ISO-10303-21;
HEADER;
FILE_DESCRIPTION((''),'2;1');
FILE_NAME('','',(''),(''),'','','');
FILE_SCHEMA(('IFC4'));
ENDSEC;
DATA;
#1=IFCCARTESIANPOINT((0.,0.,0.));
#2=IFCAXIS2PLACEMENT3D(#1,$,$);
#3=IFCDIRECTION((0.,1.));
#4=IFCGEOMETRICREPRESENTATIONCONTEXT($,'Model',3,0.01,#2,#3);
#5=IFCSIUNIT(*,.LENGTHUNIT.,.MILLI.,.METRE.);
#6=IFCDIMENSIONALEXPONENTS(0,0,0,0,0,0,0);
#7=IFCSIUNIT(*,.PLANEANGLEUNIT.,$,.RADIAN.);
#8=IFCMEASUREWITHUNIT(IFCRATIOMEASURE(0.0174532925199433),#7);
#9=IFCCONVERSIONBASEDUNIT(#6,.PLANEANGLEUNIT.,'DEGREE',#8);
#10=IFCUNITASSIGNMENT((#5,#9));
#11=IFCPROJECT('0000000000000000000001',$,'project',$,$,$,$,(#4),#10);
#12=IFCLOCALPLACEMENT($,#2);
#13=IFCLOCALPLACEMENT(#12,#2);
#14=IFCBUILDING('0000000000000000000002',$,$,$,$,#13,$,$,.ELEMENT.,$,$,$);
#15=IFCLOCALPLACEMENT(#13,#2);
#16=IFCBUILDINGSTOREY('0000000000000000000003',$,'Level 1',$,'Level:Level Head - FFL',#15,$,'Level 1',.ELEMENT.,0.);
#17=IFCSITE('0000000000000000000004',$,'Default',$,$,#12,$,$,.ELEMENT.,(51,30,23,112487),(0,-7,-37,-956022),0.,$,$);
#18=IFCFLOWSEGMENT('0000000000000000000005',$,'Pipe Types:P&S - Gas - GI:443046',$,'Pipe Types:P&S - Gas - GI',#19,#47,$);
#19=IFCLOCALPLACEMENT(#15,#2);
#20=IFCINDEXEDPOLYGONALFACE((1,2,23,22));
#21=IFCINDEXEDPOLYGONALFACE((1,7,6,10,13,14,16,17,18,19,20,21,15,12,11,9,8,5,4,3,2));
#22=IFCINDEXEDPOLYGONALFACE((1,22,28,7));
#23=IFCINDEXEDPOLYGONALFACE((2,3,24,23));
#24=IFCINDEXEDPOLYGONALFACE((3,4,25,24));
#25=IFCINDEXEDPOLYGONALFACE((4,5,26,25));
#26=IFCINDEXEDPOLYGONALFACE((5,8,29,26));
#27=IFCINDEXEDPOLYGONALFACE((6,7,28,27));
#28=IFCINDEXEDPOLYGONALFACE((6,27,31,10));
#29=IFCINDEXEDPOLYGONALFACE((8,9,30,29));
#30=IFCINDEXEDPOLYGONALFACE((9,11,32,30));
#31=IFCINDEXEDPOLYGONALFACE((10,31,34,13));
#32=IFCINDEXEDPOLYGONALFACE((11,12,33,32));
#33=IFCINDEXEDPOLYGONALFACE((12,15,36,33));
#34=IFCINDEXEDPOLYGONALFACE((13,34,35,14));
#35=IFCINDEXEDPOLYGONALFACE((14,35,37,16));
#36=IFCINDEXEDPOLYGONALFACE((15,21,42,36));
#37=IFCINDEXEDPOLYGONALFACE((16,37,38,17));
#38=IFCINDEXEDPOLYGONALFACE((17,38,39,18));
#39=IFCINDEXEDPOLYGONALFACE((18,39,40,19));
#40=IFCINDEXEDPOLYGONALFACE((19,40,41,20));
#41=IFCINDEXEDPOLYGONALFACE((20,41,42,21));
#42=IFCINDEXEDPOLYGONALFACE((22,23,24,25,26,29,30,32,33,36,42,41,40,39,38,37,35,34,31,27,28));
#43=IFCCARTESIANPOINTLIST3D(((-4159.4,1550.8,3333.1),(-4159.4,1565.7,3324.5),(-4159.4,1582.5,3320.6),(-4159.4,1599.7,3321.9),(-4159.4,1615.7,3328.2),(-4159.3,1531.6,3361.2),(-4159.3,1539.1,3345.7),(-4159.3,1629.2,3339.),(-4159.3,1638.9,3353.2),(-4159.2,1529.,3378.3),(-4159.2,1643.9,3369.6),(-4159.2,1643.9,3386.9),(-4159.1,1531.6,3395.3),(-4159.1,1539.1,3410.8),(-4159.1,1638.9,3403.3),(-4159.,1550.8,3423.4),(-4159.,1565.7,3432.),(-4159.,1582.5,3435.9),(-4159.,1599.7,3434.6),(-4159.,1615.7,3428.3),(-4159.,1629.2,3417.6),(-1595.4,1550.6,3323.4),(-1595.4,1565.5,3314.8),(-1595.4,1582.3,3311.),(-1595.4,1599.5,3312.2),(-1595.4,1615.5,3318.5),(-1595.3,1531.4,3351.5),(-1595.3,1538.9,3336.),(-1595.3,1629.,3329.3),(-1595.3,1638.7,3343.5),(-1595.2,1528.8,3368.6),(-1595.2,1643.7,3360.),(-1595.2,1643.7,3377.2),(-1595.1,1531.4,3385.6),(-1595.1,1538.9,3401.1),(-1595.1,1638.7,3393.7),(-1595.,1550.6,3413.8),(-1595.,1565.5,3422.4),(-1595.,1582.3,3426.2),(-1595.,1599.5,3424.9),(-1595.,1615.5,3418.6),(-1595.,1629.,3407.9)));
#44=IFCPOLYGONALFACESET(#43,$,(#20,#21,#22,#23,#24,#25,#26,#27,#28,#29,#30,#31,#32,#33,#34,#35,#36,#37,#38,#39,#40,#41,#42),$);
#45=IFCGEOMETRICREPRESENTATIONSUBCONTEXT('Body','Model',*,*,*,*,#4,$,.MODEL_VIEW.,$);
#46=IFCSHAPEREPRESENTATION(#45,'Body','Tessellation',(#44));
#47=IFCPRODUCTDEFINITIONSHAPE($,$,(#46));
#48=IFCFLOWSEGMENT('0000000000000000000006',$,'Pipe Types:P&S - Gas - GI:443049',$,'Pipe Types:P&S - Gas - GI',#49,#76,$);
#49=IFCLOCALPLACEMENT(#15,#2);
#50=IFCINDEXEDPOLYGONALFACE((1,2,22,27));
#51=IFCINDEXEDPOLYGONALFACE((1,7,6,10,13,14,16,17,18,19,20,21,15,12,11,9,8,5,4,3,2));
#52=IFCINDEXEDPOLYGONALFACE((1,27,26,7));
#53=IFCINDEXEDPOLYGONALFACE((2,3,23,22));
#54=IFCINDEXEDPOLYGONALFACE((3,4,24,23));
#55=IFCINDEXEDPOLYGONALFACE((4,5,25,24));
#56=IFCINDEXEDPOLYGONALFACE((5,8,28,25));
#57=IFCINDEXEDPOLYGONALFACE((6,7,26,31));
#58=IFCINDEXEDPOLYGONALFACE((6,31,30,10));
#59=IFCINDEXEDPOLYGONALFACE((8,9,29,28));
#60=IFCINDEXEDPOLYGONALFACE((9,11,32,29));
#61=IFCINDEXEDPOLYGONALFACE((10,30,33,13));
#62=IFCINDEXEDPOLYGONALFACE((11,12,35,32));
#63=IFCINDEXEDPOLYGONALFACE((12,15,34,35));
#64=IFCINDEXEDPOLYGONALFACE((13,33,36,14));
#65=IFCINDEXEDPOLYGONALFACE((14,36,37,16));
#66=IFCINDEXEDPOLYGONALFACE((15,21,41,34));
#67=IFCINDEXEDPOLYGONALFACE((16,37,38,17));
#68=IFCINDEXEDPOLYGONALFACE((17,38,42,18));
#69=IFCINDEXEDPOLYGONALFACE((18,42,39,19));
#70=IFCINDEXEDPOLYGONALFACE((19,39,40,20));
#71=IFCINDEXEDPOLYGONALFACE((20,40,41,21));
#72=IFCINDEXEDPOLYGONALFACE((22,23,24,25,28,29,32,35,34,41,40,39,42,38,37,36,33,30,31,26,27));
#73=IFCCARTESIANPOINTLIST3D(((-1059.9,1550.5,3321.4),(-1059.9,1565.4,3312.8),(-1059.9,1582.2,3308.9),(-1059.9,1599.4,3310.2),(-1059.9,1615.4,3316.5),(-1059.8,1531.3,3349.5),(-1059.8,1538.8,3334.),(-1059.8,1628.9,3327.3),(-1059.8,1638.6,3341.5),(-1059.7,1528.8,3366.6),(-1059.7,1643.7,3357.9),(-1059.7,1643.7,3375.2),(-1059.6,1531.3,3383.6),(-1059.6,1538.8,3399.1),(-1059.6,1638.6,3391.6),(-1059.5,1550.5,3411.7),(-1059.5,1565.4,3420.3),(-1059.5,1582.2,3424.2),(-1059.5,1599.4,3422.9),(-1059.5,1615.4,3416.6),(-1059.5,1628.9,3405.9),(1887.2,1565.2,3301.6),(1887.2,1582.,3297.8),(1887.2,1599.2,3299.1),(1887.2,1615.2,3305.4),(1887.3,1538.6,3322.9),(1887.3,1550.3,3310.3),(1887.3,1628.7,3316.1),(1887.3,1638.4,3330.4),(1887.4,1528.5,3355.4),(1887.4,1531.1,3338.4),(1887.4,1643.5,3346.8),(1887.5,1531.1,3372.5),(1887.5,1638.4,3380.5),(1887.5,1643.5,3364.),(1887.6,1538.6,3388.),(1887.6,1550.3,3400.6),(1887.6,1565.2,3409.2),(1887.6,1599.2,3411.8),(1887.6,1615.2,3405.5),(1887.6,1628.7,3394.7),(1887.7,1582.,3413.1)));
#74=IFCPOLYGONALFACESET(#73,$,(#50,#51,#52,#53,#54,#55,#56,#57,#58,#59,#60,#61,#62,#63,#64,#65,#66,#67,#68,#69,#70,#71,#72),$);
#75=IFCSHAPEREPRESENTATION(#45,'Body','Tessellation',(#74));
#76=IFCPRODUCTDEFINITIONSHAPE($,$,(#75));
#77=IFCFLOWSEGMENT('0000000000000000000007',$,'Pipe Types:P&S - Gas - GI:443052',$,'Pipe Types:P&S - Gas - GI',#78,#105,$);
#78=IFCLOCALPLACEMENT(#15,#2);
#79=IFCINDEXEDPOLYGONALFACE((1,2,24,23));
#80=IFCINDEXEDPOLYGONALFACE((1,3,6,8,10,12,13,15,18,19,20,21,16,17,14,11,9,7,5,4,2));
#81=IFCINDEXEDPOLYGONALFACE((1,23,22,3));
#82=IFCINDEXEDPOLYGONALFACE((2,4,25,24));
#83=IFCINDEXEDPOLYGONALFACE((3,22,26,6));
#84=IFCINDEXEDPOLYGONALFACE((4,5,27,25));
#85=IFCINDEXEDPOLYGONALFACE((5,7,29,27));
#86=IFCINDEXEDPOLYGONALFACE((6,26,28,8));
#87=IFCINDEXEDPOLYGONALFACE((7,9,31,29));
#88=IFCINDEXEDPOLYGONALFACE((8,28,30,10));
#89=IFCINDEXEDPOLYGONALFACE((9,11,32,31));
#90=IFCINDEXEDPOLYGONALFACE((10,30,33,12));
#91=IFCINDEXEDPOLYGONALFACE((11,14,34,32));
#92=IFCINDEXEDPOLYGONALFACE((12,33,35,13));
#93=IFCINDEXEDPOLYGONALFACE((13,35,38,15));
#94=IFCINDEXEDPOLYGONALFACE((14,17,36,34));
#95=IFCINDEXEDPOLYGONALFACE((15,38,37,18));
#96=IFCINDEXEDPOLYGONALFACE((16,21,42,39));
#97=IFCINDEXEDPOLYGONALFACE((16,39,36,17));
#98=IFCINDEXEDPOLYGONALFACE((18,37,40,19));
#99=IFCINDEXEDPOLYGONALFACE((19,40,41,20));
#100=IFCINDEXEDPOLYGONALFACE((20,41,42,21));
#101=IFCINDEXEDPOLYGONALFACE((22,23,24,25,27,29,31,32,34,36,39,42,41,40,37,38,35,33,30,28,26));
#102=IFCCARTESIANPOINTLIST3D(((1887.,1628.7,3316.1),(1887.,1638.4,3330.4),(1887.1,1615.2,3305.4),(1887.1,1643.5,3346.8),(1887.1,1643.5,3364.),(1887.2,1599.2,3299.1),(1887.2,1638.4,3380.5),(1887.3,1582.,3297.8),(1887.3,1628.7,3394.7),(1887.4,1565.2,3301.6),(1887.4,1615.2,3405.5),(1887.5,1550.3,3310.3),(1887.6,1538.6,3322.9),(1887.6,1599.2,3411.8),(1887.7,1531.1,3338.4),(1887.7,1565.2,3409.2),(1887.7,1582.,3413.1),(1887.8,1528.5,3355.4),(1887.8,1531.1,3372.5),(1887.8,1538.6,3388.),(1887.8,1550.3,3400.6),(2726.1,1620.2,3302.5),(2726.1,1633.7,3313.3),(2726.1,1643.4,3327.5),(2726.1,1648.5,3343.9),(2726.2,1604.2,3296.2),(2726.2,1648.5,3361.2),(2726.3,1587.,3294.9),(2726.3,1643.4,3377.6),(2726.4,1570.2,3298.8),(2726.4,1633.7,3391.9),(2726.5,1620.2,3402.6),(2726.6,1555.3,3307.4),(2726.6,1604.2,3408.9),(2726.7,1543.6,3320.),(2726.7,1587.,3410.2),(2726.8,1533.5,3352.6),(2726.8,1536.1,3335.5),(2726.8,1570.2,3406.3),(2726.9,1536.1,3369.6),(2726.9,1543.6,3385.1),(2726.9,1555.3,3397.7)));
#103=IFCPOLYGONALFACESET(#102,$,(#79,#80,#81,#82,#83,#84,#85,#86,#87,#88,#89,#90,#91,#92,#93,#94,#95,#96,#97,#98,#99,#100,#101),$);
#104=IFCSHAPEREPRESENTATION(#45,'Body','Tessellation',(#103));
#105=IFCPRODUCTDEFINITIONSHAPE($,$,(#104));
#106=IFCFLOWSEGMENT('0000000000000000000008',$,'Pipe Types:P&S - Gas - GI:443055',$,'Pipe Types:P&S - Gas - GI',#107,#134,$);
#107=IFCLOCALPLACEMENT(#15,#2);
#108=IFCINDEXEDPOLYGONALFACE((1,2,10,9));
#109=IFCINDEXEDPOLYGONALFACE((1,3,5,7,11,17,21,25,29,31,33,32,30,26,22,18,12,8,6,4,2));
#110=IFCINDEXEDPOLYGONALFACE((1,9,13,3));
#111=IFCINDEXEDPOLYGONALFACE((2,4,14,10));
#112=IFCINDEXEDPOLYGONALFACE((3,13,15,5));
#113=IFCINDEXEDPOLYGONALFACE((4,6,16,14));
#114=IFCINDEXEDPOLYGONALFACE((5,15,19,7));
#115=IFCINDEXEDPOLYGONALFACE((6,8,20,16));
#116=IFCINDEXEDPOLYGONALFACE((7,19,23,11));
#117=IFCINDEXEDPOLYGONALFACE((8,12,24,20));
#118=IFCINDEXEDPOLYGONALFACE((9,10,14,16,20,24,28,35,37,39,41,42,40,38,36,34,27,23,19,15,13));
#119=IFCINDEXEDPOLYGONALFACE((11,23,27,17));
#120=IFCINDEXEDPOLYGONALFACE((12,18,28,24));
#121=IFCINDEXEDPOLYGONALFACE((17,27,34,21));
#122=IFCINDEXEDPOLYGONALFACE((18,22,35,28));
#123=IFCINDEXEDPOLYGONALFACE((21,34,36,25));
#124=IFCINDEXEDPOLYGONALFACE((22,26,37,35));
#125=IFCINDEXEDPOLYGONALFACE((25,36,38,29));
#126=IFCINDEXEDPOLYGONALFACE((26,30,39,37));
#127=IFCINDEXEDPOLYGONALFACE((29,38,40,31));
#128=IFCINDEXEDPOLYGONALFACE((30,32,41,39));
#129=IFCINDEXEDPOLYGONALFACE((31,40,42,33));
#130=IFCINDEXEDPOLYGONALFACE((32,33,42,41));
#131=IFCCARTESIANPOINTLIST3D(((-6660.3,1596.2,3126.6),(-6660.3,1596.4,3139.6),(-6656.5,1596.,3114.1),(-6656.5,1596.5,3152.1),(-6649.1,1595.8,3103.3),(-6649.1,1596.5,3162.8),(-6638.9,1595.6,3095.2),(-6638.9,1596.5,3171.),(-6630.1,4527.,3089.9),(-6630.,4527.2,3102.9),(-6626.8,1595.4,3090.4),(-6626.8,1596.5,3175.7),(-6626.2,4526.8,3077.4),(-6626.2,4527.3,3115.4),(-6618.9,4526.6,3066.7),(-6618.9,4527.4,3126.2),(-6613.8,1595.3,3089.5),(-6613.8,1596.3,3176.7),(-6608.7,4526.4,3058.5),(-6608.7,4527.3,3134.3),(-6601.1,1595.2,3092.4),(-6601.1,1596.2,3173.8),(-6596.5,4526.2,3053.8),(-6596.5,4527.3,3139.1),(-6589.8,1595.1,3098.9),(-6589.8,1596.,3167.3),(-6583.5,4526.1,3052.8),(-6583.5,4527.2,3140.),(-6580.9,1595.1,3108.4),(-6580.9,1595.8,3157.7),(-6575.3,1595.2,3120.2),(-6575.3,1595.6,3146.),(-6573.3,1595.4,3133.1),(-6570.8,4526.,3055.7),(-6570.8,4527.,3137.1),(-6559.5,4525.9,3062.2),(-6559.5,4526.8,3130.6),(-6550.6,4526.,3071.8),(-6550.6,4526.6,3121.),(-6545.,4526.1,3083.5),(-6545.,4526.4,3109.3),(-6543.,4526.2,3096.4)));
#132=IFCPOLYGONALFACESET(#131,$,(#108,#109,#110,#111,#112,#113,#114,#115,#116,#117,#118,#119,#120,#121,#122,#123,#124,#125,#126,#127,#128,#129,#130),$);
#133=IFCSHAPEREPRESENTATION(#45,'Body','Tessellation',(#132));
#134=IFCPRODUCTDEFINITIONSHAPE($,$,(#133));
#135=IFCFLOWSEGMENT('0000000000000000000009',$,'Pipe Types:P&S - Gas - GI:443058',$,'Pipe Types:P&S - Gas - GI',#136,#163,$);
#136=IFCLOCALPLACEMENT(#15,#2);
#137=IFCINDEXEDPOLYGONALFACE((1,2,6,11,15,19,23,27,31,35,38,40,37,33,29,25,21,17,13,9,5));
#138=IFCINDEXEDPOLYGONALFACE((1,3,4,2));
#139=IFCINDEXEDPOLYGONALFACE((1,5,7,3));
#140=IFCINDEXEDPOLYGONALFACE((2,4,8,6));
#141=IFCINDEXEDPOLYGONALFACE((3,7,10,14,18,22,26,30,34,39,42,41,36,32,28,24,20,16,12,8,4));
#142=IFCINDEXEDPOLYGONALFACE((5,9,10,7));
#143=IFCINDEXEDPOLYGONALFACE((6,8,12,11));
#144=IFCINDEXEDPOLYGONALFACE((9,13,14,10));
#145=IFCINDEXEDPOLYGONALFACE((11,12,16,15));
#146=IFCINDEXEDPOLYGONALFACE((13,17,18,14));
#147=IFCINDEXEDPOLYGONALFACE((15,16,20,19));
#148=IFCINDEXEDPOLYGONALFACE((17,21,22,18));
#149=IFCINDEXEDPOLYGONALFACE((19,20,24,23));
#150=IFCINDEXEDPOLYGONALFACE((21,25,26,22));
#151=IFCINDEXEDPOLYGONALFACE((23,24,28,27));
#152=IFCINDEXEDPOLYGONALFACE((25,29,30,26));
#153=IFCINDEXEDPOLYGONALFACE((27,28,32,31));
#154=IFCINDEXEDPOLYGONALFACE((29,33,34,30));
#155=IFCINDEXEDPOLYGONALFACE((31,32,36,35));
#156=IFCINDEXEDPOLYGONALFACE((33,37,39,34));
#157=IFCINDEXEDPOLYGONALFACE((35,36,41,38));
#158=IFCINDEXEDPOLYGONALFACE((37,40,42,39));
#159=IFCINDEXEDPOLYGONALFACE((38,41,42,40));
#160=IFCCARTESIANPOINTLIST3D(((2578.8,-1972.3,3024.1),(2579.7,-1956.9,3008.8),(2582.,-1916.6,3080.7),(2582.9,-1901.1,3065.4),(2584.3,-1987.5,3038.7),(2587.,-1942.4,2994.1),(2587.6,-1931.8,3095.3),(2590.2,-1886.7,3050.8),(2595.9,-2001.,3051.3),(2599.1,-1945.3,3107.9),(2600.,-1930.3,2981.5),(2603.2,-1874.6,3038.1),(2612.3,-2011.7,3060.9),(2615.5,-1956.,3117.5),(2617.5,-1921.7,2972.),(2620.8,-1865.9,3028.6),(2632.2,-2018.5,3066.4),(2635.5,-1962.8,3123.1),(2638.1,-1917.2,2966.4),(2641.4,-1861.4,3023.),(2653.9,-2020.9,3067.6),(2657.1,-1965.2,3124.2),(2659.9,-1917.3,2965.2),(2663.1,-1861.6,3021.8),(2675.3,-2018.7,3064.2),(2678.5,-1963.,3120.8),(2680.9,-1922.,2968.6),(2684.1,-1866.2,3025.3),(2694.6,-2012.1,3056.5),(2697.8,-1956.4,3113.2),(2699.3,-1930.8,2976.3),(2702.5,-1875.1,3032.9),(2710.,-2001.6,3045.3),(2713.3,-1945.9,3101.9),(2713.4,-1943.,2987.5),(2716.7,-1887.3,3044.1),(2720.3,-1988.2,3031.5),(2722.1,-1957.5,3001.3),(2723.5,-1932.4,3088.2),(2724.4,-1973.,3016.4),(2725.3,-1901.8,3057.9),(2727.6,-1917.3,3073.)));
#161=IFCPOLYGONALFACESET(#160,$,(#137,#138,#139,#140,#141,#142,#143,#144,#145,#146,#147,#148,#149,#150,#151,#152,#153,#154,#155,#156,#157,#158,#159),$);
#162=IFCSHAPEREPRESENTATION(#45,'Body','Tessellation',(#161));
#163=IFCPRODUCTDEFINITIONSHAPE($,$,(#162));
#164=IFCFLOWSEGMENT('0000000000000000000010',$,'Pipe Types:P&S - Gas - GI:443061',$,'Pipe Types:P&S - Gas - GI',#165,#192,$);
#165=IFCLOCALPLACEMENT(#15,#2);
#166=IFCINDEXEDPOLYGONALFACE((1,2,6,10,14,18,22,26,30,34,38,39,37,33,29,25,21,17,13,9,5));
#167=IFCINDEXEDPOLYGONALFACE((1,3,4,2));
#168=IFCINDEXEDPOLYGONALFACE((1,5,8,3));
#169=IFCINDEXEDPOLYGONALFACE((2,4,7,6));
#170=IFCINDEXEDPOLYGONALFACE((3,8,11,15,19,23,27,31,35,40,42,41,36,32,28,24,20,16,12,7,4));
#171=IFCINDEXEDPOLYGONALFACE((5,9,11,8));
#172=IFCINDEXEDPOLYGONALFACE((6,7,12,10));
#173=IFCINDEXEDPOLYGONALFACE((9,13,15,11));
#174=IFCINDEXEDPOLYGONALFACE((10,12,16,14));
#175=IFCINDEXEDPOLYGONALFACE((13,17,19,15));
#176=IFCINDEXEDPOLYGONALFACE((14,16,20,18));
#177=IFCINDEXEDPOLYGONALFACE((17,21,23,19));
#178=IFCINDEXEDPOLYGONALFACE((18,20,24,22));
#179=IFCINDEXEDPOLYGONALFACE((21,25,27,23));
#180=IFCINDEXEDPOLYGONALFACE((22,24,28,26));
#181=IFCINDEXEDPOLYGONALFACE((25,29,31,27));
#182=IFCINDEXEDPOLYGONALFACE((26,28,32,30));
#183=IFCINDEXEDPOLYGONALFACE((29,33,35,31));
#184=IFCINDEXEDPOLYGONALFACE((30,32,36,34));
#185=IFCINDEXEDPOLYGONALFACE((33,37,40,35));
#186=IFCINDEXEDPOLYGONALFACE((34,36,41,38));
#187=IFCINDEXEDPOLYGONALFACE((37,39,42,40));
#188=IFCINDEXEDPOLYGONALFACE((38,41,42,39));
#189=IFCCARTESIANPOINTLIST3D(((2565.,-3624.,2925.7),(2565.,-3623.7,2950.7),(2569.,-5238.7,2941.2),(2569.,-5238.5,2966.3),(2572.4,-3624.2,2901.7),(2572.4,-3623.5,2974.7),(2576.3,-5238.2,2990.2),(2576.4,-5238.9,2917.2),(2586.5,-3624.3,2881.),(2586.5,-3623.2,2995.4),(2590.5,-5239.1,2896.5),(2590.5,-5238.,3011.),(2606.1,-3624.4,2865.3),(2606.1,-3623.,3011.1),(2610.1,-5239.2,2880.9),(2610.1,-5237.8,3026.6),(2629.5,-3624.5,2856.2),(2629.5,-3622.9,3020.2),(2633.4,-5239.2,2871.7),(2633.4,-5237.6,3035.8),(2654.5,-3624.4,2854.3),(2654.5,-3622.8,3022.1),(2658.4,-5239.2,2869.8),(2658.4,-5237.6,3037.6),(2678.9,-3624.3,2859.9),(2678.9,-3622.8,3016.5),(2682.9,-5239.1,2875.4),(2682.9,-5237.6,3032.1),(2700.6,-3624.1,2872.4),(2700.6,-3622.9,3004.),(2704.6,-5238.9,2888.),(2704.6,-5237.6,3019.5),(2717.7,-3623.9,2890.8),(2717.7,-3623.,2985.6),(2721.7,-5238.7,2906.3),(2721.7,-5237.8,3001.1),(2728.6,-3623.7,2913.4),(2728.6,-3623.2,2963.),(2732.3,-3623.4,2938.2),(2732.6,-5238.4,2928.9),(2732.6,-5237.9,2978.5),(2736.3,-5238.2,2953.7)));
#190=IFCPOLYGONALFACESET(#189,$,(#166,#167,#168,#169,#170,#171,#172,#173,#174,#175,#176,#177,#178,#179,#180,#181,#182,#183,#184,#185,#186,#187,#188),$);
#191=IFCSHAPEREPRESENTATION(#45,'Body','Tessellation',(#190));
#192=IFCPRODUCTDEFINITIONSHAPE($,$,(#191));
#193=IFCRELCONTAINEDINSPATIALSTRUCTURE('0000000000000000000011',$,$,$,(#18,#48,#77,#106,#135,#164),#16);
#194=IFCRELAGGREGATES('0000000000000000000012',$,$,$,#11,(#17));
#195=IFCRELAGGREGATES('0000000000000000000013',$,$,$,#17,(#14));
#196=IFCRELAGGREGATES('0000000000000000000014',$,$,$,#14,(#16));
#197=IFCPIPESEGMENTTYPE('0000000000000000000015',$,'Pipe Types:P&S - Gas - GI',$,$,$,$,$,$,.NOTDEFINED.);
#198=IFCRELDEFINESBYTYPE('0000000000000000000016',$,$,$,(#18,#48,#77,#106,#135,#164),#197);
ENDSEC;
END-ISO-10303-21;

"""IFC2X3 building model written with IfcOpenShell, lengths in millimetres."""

from ifc_helpers import new_model, entity, si_unit, converted_unit, direction, frame, frame_2d, origin, origin_2d_with_axis, place, context, subcontext, project, spatial, circle, extrude, type_object, element, save


model = new_model("IFC2X3")

# Units and contexts
model_context = context("Model", 3, precision=0.01, world=origin(), true_north=direction((0.0, 1.0)))
body_context = subcontext(model_context, "Body", "Model", "MODEL_VIEW")
ifc_project = project(units=[si_unit("LENGTHUNIT", "METRE", prefix="MILLI"), converted_unit("PLANEANGLEUNIT", "DEGREE", entity("IfcRatioMeasure", 0.0174532925199433), si_unit("PLANEANGLEUNIT", "RADIAN"), dimensions=[0, 0, 0, 0, 0, 0, 0])], contexts=[model_context])

# Site, building, storey
site_placement = place(None, origin())
site = spatial("IfcSite", under=ifc_project, at=site_placement, Name="Default", CompositionType="ELEMENT", RefLatitude=(51, 30, 23, 112487), RefLongitude=(0, -7, -37, -956022), RefElevation=0.0)
building_placement = place(site_placement, origin())
building = spatial("IfcBuilding", under=site, at=building_placement, CompositionType="ELEMENT")
storey_placement = place(building_placement, origin())
storey = spatial("IfcBuildingStorey", under=building, at=storey_placement, Name="Level 1", ObjectType="Level:Level Head - FFL", LongName="Level 1", CompositionType="ELEMENT", Elevation=0.0)

# Flow segments
pipe_segment_type = type_object("IfcPipeSegmentType", Name="Pipe Types:P&S - Gas - GI", PredefinedType="NOTDEFINED")
flow_segment_1_placement = place(storey_placement, origin())
element("IfcFlowSegment", 1, at=flow_segment_1_placement, inside=storey, type_object=pipe_segment_type, Name="Pipe Types:P&S - Gas - GI:443046", ObjectType="Pipe Types:P&S - Gas - GI", context=body_context, shape_type="SweptSolid", body=[
    extrude(circle(Radius=57.8, at=frame_2d((0.0, 0.0), x_axis=(1.0, 0.0))), frame((-1595.2, 1586.6, 3368.6), z_axis=(-0.999993, 0.000082, 0.003774), x_axis=(-0.000082, -1.0, 0.0)), (0.0, 0.0, 1.0), 2564.0),
])
flow_segment_2_placement = place(storey_placement, origin())
element("IfcFlowSegment", 2, at=flow_segment_2_placement, inside=storey, type_object=pipe_segment_type, Name="Pipe Types:P&S - Gas - GI:443049", ObjectType="Pipe Types:P&S - Gas - GI", context=body_context, shape_type="SweptSolid", body=[
    extrude(circle(Radius=57.8, at=frame_2d((0.0, 0.0), x_axis=(1.0, 0.0))), frame((1887.4, 1586.3, 3355.4), z_axis=(-0.999993, 0.000082, 0.003774), x_axis=(-0.000082, -1.0, 0.0)), (0.0, 0.0, 1.0), 2947.2),
])
flow_segment_3_placement = place(storey_placement, origin())
element("IfcFlowSegment", 3, at=flow_segment_3_placement, inside=storey, type_object=pipe_segment_type, Name="Pipe Types:P&S - Gas - GI:443052", ObjectType="Pipe Types:P&S - Gas - GI", context=body_context, shape_type="SweptSolid", body=[
    extrude(circle(Radius=57.8, at=origin_2d_with_axis()), frame((2726.5, 1591.3, 3352.6), z_axis=(-0.999976, -0.005975, 0.003428), x_axis=(0.005975, -0.999982, 0.0)), (0.0, 0.0, 1.0), 839.1),
])
flow_segment_4_placement = place(storey_placement, origin())
element("IfcFlowSegment", 4, at=flow_segment_4_placement, inside=storey, type_object=pipe_segment_type, Name="Pipe Types:P&S - Gas - GI:443055", ObjectType="Pipe Types:P&S - Gas - GI", context=body_context, shape_type="SweptSolid", body=[
    extrude(circle(Radius=43.7, at=frame_2d((0.0, 0.0), x_axis=(1.0, 0.0))), frame((-6586.8, 4526.6, 3096.4), z_axis=(-0.010329, -0.999868, 0.012514), x_axis=(0.999947, -0.010329, 0.0)), (0.0, 0.0, 1.0), 2931.2),
])
flow_segment_5_placement = place(storey_placement, origin())
element("IfcFlowSegment", 5, at=flow_segment_5_placement, inside=storey, type_object=pipe_segment_type, Name="Pipe Types:P&S - Gas - GI:443058", ObjectType="Pipe Types:P&S - Gas - GI", context=body_context, shape_type="SweptSolid", body=[
    extrude(circle(Radius=73.1, at=frame_2d((0.0, 0.0), x_axis=(1.0, 0.0))), frame((2651.4, -1968.8, 3016.4), z_axis=(0.040698, 0.700832, 0.712164), x_axis=(0.998318, -0.057973, 0.0)), (0.0, 0.0, 1.0), 79.5),
])
flow_segment_6_placement = place(storey_placement, origin())
element("IfcFlowSegment", 6, at=flow_segment_6_placement, inside=storey, type_object=pipe_segment_type, Name="Pipe Types:P&S - Gas - GI:443061", ObjectType="Pipe Types:P&S - Gas - GI", context=body_context, shape_type="SweptSolid", body=[
    extrude(circle(Radius=84.1, at=frame_2d((0.0, 0.0), x_axis=(1.0, 0.0))), frame((2648.2, -3623.6, 2938.2), z_axis=(0.002459, -0.999951, 0.009624), x_axis=(0.999997, 0.002459, 0.0)), (0.0, 0.0, 1.0), 1614.8),
])

save(model, "model.ifc")
